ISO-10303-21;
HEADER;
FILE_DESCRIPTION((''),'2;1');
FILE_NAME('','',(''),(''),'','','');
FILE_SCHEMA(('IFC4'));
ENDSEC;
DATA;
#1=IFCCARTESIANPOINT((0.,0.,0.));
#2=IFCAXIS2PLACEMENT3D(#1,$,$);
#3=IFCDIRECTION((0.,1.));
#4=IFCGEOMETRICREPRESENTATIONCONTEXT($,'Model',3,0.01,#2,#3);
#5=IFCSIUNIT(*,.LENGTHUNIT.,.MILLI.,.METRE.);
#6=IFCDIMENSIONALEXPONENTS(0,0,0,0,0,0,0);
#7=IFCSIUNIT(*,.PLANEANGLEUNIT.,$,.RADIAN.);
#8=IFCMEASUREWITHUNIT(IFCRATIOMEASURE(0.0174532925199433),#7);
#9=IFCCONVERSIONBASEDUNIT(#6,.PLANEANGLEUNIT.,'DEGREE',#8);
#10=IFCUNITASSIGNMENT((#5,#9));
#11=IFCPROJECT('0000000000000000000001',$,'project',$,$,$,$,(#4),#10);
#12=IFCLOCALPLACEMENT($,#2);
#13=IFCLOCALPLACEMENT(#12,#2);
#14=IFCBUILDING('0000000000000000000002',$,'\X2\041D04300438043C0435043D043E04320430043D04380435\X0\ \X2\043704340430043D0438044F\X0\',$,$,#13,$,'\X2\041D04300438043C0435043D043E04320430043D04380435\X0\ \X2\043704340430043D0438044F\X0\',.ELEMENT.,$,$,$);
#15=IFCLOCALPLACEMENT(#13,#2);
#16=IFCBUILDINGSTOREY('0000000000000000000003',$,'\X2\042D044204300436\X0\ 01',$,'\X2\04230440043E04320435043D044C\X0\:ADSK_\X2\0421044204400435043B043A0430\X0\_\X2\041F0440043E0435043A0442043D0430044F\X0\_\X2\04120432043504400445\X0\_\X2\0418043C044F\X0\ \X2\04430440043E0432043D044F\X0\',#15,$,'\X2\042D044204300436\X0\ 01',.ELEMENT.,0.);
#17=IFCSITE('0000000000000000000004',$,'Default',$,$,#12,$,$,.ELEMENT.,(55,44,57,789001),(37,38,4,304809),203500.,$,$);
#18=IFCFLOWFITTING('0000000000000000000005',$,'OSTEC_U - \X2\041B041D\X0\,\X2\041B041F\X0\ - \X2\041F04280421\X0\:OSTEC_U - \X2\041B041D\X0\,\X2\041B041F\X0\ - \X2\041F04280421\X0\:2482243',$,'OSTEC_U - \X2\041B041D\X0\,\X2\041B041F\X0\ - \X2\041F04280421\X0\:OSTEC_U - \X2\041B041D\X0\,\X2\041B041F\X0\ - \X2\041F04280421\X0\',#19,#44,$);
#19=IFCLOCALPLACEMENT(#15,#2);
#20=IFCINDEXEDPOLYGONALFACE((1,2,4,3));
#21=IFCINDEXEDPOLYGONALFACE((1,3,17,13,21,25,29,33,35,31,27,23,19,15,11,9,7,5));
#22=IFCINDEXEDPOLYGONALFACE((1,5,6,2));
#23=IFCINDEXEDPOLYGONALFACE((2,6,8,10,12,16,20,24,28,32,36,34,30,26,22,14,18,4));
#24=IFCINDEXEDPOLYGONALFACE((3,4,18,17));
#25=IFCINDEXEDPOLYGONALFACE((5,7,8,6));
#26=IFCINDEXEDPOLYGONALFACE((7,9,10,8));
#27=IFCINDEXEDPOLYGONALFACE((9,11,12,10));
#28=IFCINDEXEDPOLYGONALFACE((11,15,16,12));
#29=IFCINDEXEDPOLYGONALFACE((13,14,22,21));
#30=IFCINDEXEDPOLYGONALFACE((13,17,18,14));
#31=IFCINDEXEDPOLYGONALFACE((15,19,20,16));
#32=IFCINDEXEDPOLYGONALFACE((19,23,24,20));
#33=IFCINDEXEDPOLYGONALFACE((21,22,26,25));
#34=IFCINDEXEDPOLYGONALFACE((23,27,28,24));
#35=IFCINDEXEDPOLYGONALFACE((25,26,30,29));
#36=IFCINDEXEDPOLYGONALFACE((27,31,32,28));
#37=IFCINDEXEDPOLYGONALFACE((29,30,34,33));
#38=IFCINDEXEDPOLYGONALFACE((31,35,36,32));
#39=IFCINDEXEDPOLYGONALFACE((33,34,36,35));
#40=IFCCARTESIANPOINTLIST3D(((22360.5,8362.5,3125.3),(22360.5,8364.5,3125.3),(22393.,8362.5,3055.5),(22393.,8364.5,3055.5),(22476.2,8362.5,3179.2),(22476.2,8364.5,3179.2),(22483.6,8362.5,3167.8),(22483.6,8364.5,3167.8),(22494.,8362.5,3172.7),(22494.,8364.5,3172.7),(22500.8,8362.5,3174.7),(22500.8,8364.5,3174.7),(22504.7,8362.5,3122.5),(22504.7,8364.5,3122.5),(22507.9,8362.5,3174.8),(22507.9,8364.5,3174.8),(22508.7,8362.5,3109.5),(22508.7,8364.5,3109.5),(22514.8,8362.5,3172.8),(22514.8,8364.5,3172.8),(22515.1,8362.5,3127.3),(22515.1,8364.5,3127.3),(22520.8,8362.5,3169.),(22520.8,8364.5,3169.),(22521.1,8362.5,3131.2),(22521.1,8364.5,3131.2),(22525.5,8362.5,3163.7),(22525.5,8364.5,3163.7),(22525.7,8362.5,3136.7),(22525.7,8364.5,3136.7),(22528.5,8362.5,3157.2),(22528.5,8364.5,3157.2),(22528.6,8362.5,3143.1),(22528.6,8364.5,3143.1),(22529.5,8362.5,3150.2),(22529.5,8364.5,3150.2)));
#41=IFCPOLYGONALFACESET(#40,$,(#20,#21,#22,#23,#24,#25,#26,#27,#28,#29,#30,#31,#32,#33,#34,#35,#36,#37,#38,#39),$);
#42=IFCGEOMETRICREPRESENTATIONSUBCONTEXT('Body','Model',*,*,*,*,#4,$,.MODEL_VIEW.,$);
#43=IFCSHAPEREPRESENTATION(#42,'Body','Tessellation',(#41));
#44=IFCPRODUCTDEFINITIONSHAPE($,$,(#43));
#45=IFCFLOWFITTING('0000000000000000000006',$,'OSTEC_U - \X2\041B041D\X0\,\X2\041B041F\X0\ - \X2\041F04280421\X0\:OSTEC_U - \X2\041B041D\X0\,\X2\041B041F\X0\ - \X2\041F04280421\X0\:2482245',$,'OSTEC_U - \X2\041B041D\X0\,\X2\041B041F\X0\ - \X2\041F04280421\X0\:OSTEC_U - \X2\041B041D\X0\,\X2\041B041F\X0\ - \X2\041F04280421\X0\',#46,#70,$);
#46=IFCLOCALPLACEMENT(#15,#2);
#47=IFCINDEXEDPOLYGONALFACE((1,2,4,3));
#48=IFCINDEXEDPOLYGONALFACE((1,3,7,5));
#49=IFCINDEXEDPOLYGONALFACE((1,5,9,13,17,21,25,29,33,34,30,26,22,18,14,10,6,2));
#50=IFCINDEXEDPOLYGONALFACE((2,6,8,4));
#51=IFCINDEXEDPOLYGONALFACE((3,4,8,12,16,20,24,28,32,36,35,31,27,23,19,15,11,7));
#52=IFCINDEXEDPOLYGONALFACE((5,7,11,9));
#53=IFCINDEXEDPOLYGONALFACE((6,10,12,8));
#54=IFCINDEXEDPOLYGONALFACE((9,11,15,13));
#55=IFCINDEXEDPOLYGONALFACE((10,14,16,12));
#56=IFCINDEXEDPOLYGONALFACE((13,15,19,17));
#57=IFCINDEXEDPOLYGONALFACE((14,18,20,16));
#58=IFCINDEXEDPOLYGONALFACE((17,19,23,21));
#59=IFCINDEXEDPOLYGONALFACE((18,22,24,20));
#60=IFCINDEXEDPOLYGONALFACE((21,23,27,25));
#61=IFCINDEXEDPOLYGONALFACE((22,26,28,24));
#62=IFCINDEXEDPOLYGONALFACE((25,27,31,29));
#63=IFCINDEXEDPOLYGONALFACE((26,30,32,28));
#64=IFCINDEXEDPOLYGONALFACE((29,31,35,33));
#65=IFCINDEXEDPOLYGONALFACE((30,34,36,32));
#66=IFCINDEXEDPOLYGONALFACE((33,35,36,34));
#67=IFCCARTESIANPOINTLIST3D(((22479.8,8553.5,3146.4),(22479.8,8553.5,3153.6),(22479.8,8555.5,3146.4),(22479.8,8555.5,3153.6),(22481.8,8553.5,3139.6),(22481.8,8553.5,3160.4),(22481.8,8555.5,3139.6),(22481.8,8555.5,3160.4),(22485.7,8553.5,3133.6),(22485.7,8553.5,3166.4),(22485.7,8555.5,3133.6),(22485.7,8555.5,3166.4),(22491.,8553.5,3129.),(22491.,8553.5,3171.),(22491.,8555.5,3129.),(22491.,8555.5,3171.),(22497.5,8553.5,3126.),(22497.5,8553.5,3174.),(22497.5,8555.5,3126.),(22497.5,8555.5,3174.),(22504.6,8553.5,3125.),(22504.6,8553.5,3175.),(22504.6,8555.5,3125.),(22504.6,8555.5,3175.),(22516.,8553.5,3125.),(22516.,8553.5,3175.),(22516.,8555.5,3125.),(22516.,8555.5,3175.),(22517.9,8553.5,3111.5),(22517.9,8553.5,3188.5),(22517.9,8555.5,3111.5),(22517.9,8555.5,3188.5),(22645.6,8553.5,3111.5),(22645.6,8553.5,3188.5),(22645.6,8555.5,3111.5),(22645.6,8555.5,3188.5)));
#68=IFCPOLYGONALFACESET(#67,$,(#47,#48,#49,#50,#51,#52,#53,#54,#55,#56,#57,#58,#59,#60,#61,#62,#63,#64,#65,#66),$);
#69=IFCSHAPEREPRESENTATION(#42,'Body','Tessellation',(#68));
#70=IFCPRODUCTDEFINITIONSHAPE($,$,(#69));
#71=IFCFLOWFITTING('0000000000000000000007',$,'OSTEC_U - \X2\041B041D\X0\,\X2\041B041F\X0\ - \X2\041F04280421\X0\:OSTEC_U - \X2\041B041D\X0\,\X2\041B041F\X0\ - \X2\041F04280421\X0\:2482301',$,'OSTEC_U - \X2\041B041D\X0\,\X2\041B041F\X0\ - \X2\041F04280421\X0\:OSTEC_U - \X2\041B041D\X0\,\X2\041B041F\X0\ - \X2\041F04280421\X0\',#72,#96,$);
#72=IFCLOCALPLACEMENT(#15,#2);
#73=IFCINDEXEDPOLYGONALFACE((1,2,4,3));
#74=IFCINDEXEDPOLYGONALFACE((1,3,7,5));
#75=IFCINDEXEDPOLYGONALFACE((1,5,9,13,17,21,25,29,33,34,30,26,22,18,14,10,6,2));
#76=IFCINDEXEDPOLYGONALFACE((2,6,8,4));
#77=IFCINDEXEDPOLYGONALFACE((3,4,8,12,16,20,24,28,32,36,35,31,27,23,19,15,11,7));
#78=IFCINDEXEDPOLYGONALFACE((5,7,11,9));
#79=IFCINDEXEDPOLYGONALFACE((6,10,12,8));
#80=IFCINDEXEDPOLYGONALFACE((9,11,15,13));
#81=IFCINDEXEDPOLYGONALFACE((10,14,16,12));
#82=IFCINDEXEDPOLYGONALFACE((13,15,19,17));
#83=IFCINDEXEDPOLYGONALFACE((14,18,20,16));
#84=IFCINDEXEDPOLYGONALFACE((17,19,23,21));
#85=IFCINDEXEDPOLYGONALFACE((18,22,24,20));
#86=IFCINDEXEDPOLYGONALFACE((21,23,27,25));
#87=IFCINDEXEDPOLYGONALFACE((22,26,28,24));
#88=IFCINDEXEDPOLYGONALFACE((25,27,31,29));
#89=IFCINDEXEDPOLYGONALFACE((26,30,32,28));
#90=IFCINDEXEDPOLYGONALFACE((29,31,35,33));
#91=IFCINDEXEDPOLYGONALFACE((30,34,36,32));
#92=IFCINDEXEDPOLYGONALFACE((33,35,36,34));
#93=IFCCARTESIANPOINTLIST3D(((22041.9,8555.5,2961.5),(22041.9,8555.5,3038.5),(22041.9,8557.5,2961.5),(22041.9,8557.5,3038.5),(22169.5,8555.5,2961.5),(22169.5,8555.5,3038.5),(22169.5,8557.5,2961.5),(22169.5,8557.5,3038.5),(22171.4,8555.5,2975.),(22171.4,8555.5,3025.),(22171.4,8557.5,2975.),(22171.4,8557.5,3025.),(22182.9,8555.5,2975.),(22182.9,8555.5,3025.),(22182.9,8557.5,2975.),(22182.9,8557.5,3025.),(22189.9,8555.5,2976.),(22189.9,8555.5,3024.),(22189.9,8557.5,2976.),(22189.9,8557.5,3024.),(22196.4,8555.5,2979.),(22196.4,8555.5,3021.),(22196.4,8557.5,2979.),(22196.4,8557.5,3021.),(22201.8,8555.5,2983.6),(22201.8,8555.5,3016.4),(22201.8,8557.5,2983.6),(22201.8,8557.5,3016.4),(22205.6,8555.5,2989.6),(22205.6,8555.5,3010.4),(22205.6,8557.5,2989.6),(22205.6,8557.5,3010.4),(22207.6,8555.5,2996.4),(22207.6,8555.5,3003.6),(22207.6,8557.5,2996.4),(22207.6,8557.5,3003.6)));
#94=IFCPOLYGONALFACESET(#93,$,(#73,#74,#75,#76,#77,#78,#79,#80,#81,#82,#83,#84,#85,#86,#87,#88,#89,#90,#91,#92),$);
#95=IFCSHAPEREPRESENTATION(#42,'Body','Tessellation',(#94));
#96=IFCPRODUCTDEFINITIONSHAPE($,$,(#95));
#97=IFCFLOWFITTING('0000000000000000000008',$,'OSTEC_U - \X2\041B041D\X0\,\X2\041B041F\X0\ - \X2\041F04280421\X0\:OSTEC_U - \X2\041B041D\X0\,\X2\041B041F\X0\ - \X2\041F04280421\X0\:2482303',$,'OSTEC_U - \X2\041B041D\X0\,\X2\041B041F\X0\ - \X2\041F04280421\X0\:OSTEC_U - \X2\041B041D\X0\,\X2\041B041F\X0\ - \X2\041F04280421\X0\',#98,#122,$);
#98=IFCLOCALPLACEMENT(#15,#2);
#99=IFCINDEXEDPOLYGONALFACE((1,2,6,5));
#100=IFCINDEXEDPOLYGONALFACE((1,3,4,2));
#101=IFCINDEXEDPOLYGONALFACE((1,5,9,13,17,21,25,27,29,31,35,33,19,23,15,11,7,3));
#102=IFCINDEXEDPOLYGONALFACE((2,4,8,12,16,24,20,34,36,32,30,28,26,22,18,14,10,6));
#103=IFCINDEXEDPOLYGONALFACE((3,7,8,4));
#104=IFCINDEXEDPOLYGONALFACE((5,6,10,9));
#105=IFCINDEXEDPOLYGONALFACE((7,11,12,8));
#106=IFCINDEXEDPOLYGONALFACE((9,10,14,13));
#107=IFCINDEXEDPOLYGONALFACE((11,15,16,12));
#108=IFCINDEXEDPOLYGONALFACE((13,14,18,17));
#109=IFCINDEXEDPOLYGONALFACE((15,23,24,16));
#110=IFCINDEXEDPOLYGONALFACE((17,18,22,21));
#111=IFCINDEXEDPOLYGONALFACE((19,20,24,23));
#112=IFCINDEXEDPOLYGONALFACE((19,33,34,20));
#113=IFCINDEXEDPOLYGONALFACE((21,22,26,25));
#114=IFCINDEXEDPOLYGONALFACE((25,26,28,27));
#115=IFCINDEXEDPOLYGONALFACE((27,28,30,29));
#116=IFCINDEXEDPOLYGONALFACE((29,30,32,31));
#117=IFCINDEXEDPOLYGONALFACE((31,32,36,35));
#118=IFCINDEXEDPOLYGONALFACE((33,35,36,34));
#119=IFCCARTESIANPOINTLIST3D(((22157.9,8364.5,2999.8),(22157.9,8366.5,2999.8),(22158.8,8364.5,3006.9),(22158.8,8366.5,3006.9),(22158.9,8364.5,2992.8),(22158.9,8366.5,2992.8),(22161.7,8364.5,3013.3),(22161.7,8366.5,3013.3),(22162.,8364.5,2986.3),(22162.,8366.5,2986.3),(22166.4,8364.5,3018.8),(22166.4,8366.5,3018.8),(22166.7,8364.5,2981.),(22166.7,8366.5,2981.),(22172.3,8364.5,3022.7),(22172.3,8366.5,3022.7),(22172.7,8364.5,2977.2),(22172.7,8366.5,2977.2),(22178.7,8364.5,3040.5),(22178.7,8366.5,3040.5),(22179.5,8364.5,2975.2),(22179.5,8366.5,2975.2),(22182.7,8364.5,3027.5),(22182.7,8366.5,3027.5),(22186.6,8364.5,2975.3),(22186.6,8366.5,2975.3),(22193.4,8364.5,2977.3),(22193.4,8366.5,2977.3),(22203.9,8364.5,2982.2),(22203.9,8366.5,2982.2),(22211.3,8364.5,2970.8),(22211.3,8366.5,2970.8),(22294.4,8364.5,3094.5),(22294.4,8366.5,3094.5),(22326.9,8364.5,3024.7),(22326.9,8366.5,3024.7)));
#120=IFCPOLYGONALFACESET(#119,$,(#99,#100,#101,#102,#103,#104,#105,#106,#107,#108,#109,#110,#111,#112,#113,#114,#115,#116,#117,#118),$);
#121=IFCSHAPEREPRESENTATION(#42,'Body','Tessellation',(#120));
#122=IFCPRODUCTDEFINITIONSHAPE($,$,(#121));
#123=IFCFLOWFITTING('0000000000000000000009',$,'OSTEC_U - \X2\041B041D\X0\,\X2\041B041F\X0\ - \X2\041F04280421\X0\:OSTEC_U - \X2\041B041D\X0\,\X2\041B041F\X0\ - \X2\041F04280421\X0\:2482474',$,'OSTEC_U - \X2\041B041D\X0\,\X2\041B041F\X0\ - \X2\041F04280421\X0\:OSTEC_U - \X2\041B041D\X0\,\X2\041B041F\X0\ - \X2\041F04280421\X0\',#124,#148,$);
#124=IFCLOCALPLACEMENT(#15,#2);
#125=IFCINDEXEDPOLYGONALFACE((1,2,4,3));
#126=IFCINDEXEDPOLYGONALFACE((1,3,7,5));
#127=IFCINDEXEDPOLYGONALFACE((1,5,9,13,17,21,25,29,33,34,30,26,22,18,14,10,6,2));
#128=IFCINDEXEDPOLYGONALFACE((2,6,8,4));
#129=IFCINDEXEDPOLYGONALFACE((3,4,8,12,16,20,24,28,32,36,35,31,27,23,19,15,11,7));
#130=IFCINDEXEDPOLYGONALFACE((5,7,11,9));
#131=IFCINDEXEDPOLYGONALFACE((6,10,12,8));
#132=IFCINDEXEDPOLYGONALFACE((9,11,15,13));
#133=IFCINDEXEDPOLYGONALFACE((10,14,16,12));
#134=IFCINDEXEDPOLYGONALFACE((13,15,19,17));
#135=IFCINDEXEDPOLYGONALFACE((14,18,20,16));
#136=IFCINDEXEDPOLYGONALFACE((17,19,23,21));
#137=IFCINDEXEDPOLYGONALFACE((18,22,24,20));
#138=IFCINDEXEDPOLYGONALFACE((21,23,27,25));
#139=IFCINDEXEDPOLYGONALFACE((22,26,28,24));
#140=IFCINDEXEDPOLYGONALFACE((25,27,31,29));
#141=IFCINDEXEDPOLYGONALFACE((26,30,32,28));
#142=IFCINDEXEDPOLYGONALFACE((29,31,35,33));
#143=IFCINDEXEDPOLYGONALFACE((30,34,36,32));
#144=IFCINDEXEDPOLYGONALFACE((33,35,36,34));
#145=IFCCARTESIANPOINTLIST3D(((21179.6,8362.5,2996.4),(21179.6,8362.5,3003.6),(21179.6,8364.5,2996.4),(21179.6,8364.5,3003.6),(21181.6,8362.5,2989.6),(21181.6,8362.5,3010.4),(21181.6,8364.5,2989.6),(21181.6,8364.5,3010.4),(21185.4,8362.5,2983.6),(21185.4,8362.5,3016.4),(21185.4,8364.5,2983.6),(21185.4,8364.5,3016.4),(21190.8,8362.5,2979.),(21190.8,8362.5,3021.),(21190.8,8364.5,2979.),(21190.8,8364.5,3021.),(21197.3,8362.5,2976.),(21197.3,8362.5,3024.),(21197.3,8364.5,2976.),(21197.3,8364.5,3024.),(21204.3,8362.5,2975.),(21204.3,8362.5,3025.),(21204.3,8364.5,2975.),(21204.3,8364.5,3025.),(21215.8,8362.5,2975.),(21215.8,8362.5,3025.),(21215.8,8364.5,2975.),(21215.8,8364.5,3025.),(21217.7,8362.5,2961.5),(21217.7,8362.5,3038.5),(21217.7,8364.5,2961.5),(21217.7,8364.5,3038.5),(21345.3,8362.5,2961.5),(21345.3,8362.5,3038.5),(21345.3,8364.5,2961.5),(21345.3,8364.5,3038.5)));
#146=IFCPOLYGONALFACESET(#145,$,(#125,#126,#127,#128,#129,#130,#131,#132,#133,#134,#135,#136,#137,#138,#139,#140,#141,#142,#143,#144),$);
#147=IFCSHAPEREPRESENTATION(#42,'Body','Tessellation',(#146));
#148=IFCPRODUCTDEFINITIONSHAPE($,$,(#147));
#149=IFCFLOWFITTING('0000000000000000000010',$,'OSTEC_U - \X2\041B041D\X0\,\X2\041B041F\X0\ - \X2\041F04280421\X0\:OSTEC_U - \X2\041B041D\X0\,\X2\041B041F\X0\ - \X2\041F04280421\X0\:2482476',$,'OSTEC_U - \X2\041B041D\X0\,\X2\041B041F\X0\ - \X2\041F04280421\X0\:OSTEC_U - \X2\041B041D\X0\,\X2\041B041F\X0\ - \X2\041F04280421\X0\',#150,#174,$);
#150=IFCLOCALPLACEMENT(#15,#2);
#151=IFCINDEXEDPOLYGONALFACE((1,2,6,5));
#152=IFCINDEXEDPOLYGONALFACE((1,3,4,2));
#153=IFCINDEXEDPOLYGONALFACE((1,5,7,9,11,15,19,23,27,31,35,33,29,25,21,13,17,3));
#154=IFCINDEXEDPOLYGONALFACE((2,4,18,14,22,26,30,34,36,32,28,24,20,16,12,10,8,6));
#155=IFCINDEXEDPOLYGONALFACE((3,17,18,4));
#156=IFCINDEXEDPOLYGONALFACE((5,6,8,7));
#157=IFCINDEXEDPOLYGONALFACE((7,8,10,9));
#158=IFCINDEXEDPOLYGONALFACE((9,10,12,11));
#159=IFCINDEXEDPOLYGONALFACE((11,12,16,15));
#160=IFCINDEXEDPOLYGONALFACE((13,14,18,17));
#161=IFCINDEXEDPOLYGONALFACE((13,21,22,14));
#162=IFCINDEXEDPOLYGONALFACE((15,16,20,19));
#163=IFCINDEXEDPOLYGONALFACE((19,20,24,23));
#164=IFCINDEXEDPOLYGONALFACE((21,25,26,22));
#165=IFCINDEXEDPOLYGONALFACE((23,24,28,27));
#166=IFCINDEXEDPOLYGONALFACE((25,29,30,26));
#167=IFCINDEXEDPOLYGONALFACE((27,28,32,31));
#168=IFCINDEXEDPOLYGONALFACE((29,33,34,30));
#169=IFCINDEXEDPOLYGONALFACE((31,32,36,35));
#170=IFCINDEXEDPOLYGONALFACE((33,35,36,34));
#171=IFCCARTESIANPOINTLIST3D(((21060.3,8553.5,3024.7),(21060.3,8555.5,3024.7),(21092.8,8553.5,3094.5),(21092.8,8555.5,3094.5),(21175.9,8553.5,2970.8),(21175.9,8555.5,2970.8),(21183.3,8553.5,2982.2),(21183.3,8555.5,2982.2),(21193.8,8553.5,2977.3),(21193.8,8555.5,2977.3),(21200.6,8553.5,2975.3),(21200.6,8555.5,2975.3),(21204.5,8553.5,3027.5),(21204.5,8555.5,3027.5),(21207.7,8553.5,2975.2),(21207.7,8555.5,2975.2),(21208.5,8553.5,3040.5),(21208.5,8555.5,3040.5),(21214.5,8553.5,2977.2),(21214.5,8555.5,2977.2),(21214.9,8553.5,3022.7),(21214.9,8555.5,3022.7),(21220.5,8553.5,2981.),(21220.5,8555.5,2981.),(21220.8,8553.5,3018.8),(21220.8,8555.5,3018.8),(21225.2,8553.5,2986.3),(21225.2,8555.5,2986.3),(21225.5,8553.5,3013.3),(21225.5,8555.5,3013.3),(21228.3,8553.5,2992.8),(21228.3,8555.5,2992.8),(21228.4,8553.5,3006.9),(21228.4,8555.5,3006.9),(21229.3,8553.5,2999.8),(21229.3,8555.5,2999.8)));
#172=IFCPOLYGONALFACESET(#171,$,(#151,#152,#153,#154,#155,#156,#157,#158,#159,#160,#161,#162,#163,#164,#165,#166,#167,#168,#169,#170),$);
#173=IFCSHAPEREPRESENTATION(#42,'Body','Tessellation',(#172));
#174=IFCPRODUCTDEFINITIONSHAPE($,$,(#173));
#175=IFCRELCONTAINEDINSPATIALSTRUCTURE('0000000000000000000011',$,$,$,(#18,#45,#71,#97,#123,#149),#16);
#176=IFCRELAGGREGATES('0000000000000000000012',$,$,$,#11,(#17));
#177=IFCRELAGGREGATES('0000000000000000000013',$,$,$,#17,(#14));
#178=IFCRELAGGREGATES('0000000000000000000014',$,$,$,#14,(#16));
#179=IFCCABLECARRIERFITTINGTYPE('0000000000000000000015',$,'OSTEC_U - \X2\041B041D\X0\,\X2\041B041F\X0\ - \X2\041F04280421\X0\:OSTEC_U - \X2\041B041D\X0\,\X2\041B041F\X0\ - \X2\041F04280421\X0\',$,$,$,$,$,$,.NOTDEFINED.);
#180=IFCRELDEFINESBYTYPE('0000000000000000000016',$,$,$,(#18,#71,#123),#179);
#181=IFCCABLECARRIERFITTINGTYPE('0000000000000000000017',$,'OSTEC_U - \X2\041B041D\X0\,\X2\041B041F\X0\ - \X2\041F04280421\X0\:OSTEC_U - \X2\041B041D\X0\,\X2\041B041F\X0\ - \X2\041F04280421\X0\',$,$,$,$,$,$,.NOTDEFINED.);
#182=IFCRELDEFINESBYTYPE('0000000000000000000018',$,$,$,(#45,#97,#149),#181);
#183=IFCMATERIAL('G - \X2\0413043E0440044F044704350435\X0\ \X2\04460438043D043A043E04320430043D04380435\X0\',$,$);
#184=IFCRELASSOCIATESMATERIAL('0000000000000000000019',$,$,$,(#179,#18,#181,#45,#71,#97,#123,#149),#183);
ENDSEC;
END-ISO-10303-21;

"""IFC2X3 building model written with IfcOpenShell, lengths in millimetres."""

from ifc_helpers import new_model, entity, si_unit, converted_unit, direction, frame, frame_2d, origin, place, context, subcontext, project, spatial, polyline, circle_curve, parameter, trimmed, segment, composite_curve, outline, extrude, source, transform, mapped, material, type_object, type_shapes, element, save


model = new_model("IFC2X3")

# Units and contexts
model_context = context("Model", 3, precision=0.01, world=origin(), true_north=direction((0.0, 1.0)))
body_context = subcontext(model_context, "Body", "Model", "MODEL_VIEW")
ifc_project = project(units=[si_unit("LENGTHUNIT", "METRE", prefix="MILLI"), converted_unit("PLANEANGLEUNIT", "DEGREE", entity("IfcRatioMeasure", 0.0174532925199433), si_unit("PLANEANGLEUNIT", "RADIAN"), dimensions=[0, 0, 0, 0, 0, 0, 0])], contexts=[model_context])

# Site, building, storey
site_placement = place(None, origin())
site = spatial("IfcSite", under=ifc_project, at=site_placement, Name="Default", CompositionType="ELEMENT", RefLatitude=(55, 44, 57, 789001), RefLongitude=(37, 38, 4, 304809), RefElevation=203500.0)
building_placement = place(site_placement, origin())
building = spatial("IfcBuilding", under=site, at=building_placement, Name="Наименование здания", LongName="Наименование здания", CompositionType="ELEMENT")
storey_placement = place(building_placement, origin())
storey = spatial("IfcBuildingStorey", under=building, at=storey_placement, Name="Этаж 01", ObjectType="Уровень:ADSK_Стрелка_Проектная_Вверх_Имя уровня", LongName="Этаж 01", CompositionType="ELEMENT", Elevation=0.0)

# Flow fittings
ifc_material = material(Name="G - Горячее цинкование")
cable_carrier_fitting_type_1 = type_object("IfcCableCarrierFittingType", Name="OSTEC_U - ЛН,ЛП - ПШС:OSTEC_U - ЛН,ЛП - ПШС", PredefinedType="NOTDEFINED", material=ifc_material)
shared_shape_1 = source(origin(), body_context, "Body", "SweptSolid", [
    extrude(outline(composite_curve([segment(trimmed(circle_curve(frame_2d((-41.5, 0.0), x_axis=(1.0, 0.0)), 25.0), [parameter(90.0)], [parameter(270.0)], True, "PARAMETER"), True, "CONTINUOUS"), segment(polyline([(-41.5, -25.0), (-30.0, -25.0)]), True, "CONTINUOUS"), segment(polyline([(-30.0, -25.0), (-28.1, -38.5)]), True, "CONTINUOUS"), segment(polyline([(-28.1, -38.5), (99.5, -38.5)]), True, "CONTINUOUS"), segment(polyline([(99.5, -38.5), (99.5, 38.5)]), True, "CONTINUOUS"), segment(polyline([(99.5, 38.5), (-28.1, 38.5)]), True, "CONTINUOUS"), segment(polyline([(-28.1, 38.5), (-30.0, 25.0)]), True, "CONTINUOUS"), segment(polyline([(-30.0, 25.0), (-41.5, 25.0)]), True, "CONTINUOUS")], self_intersect=False)), frame((41.5, 0.0, 0.0), z_axis=(0.0, 0.0, -1.0), x_axis=(1.0, 0.0, 0.0)), (0.0, 0.0, -1.0), 2.0),
])
type_shapes(cable_carrier_fitting_type_1, [shared_shape_1])
flow_fitting_1_placement = place(storey_placement, frame((22504.5, 8364.5, 3150.0), z_axis=(0.0, -1.0, 0.0), x_axis=(-0.906308, 0.0, -0.422618)))
element("IfcFlowFitting", 1, at=flow_fitting_1_placement, inside=storey, type_object=cable_carrier_fitting_type_1, material=ifc_material, Name="OSTEC_U - ЛН,ЛП - ПШС:OSTEC_U - ЛН,ЛП - ПШС:2482243", ObjectType="OSTEC_U - ЛН,ЛП - ПШС:OSTEC_U - ЛН,ЛП - ПШС", context=body_context, shape_type="MappedRepresentation", body=[
    mapped(shared_shape_1, transform((0.0, 0.0, 0.0), scale=1.0)),
])
cable_carrier_fitting_type_2 = type_object("IfcCableCarrierFittingType", Name="OSTEC_U - ЛН,ЛП - ПШС:OSTEC_U - ЛН,ЛП - ПШС", PredefinedType="NOTDEFINED", material=ifc_material)
type_shapes(cable_carrier_fitting_type_2, [shared_shape_1])
flow_fitting_2_placement = place(storey_placement, frame((22504.5, 8553.5, 3150.0), z_axis=(0.0, 1.0, 0.0), x_axis=(1.0, 0.0, 0.0)))
element("IfcFlowFitting", 2, at=flow_fitting_2_placement, inside=storey, type_object=cable_carrier_fitting_type_2, material=ifc_material, Name="OSTEC_U - ЛН,ЛП - ПШС:OSTEC_U - ЛН,ЛП - ПШС:2482245", ObjectType="OSTEC_U - ЛН,ЛП - ПШС:OSTEC_U - ЛН,ЛП - ПШС", context=body_context, shape_type="MappedRepresentation", body=[
    mapped(shared_shape_1, transform((0.0, 0.0, 0.0), scale=1.0)),
])
flow_fitting_3_placement = place(storey_placement, frame((22182.9, 8555.5, 3000.0), z_axis=(0.0, 1.0, 0.0), x_axis=(-1.0, 0.0, 0.0)))
element("IfcFlowFitting", 3, at=flow_fitting_3_placement, inside=storey, type_object=cable_carrier_fitting_type_1, material=ifc_material, Name="OSTEC_U - ЛН,ЛП - ПШС:OSTEC_U - ЛН,ЛП - ПШС:2482301", ObjectType="OSTEC_U - ЛН,ЛП - ПШС:OSTEC_U - ЛН,ЛП - ПШС", context=body_context, shape_type="MappedRepresentation", body=[
    mapped(shared_shape_1, transform((0.0, 0.0, 0.0), scale=1.0)),
])
flow_fitting_4_placement = place(storey_placement, frame((22182.9, 8366.5, 3000.0), z_axis=(0.0, -1.0, 0.0), x_axis=(0.906308, 0.0, 0.422618)))
element("IfcFlowFitting", 4, at=flow_fitting_4_placement, inside=storey, type_object=cable_carrier_fitting_type_2, material=ifc_material, Name="OSTEC_U - ЛН,ЛП - ПШС:OSTEC_U - ЛН,ЛП - ПШС:2482303", ObjectType="OSTEC_U - ЛН,ЛП - ПШС:OSTEC_U - ЛН,ЛП - ПШС", context=body_context, shape_type="MappedRepresentation", body=[
    mapped(shared_shape_1, transform((0.0, 0.0, 0.0), scale=1.0)),
])
flow_fitting_5_placement = place(storey_placement, frame((21204.3, 8364.5, 3000.0), z_axis=(0.0, -1.0, 0.0), x_axis=(1.0, 0.0, 0.0)))
element("IfcFlowFitting", 5, at=flow_fitting_5_placement, inside=storey, type_object=cable_carrier_fitting_type_1, material=ifc_material, Name="OSTEC_U - ЛН,ЛП - ПШС:OSTEC_U - ЛН,ЛП - ПШС:2482474", ObjectType="OSTEC_U - ЛН,ЛП - ПШС:OSTEC_U - ЛН,ЛП - ПШС", context=body_context, shape_type="MappedRepresentation", body=[
    mapped(shared_shape_1, transform((0.0, 0.0, 0.0), scale=1.0)),
])
flow_fitting_6_placement = place(storey_placement, frame((21204.3, 8553.5, 3000.0), z_axis=(0.0, 1.0, 0.0), x_axis=(-0.906308, 0.0, 0.422618)))
element("IfcFlowFitting", 6, at=flow_fitting_6_placement, inside=storey, type_object=cable_carrier_fitting_type_2, material=ifc_material, Name="OSTEC_U - ЛН,ЛП - ПШС:OSTEC_U - ЛН,ЛП - ПШС:2482476", ObjectType="OSTEC_U - ЛН,ЛП - ПШС:OSTEC_U - ЛН,ЛП - ПШС", context=body_context, shape_type="MappedRepresentation", body=[
    mapped(shared_shape_1, transform((0.0, 0.0, 0.0), scale=1.0)),
])

save(model, "model.ifc")
